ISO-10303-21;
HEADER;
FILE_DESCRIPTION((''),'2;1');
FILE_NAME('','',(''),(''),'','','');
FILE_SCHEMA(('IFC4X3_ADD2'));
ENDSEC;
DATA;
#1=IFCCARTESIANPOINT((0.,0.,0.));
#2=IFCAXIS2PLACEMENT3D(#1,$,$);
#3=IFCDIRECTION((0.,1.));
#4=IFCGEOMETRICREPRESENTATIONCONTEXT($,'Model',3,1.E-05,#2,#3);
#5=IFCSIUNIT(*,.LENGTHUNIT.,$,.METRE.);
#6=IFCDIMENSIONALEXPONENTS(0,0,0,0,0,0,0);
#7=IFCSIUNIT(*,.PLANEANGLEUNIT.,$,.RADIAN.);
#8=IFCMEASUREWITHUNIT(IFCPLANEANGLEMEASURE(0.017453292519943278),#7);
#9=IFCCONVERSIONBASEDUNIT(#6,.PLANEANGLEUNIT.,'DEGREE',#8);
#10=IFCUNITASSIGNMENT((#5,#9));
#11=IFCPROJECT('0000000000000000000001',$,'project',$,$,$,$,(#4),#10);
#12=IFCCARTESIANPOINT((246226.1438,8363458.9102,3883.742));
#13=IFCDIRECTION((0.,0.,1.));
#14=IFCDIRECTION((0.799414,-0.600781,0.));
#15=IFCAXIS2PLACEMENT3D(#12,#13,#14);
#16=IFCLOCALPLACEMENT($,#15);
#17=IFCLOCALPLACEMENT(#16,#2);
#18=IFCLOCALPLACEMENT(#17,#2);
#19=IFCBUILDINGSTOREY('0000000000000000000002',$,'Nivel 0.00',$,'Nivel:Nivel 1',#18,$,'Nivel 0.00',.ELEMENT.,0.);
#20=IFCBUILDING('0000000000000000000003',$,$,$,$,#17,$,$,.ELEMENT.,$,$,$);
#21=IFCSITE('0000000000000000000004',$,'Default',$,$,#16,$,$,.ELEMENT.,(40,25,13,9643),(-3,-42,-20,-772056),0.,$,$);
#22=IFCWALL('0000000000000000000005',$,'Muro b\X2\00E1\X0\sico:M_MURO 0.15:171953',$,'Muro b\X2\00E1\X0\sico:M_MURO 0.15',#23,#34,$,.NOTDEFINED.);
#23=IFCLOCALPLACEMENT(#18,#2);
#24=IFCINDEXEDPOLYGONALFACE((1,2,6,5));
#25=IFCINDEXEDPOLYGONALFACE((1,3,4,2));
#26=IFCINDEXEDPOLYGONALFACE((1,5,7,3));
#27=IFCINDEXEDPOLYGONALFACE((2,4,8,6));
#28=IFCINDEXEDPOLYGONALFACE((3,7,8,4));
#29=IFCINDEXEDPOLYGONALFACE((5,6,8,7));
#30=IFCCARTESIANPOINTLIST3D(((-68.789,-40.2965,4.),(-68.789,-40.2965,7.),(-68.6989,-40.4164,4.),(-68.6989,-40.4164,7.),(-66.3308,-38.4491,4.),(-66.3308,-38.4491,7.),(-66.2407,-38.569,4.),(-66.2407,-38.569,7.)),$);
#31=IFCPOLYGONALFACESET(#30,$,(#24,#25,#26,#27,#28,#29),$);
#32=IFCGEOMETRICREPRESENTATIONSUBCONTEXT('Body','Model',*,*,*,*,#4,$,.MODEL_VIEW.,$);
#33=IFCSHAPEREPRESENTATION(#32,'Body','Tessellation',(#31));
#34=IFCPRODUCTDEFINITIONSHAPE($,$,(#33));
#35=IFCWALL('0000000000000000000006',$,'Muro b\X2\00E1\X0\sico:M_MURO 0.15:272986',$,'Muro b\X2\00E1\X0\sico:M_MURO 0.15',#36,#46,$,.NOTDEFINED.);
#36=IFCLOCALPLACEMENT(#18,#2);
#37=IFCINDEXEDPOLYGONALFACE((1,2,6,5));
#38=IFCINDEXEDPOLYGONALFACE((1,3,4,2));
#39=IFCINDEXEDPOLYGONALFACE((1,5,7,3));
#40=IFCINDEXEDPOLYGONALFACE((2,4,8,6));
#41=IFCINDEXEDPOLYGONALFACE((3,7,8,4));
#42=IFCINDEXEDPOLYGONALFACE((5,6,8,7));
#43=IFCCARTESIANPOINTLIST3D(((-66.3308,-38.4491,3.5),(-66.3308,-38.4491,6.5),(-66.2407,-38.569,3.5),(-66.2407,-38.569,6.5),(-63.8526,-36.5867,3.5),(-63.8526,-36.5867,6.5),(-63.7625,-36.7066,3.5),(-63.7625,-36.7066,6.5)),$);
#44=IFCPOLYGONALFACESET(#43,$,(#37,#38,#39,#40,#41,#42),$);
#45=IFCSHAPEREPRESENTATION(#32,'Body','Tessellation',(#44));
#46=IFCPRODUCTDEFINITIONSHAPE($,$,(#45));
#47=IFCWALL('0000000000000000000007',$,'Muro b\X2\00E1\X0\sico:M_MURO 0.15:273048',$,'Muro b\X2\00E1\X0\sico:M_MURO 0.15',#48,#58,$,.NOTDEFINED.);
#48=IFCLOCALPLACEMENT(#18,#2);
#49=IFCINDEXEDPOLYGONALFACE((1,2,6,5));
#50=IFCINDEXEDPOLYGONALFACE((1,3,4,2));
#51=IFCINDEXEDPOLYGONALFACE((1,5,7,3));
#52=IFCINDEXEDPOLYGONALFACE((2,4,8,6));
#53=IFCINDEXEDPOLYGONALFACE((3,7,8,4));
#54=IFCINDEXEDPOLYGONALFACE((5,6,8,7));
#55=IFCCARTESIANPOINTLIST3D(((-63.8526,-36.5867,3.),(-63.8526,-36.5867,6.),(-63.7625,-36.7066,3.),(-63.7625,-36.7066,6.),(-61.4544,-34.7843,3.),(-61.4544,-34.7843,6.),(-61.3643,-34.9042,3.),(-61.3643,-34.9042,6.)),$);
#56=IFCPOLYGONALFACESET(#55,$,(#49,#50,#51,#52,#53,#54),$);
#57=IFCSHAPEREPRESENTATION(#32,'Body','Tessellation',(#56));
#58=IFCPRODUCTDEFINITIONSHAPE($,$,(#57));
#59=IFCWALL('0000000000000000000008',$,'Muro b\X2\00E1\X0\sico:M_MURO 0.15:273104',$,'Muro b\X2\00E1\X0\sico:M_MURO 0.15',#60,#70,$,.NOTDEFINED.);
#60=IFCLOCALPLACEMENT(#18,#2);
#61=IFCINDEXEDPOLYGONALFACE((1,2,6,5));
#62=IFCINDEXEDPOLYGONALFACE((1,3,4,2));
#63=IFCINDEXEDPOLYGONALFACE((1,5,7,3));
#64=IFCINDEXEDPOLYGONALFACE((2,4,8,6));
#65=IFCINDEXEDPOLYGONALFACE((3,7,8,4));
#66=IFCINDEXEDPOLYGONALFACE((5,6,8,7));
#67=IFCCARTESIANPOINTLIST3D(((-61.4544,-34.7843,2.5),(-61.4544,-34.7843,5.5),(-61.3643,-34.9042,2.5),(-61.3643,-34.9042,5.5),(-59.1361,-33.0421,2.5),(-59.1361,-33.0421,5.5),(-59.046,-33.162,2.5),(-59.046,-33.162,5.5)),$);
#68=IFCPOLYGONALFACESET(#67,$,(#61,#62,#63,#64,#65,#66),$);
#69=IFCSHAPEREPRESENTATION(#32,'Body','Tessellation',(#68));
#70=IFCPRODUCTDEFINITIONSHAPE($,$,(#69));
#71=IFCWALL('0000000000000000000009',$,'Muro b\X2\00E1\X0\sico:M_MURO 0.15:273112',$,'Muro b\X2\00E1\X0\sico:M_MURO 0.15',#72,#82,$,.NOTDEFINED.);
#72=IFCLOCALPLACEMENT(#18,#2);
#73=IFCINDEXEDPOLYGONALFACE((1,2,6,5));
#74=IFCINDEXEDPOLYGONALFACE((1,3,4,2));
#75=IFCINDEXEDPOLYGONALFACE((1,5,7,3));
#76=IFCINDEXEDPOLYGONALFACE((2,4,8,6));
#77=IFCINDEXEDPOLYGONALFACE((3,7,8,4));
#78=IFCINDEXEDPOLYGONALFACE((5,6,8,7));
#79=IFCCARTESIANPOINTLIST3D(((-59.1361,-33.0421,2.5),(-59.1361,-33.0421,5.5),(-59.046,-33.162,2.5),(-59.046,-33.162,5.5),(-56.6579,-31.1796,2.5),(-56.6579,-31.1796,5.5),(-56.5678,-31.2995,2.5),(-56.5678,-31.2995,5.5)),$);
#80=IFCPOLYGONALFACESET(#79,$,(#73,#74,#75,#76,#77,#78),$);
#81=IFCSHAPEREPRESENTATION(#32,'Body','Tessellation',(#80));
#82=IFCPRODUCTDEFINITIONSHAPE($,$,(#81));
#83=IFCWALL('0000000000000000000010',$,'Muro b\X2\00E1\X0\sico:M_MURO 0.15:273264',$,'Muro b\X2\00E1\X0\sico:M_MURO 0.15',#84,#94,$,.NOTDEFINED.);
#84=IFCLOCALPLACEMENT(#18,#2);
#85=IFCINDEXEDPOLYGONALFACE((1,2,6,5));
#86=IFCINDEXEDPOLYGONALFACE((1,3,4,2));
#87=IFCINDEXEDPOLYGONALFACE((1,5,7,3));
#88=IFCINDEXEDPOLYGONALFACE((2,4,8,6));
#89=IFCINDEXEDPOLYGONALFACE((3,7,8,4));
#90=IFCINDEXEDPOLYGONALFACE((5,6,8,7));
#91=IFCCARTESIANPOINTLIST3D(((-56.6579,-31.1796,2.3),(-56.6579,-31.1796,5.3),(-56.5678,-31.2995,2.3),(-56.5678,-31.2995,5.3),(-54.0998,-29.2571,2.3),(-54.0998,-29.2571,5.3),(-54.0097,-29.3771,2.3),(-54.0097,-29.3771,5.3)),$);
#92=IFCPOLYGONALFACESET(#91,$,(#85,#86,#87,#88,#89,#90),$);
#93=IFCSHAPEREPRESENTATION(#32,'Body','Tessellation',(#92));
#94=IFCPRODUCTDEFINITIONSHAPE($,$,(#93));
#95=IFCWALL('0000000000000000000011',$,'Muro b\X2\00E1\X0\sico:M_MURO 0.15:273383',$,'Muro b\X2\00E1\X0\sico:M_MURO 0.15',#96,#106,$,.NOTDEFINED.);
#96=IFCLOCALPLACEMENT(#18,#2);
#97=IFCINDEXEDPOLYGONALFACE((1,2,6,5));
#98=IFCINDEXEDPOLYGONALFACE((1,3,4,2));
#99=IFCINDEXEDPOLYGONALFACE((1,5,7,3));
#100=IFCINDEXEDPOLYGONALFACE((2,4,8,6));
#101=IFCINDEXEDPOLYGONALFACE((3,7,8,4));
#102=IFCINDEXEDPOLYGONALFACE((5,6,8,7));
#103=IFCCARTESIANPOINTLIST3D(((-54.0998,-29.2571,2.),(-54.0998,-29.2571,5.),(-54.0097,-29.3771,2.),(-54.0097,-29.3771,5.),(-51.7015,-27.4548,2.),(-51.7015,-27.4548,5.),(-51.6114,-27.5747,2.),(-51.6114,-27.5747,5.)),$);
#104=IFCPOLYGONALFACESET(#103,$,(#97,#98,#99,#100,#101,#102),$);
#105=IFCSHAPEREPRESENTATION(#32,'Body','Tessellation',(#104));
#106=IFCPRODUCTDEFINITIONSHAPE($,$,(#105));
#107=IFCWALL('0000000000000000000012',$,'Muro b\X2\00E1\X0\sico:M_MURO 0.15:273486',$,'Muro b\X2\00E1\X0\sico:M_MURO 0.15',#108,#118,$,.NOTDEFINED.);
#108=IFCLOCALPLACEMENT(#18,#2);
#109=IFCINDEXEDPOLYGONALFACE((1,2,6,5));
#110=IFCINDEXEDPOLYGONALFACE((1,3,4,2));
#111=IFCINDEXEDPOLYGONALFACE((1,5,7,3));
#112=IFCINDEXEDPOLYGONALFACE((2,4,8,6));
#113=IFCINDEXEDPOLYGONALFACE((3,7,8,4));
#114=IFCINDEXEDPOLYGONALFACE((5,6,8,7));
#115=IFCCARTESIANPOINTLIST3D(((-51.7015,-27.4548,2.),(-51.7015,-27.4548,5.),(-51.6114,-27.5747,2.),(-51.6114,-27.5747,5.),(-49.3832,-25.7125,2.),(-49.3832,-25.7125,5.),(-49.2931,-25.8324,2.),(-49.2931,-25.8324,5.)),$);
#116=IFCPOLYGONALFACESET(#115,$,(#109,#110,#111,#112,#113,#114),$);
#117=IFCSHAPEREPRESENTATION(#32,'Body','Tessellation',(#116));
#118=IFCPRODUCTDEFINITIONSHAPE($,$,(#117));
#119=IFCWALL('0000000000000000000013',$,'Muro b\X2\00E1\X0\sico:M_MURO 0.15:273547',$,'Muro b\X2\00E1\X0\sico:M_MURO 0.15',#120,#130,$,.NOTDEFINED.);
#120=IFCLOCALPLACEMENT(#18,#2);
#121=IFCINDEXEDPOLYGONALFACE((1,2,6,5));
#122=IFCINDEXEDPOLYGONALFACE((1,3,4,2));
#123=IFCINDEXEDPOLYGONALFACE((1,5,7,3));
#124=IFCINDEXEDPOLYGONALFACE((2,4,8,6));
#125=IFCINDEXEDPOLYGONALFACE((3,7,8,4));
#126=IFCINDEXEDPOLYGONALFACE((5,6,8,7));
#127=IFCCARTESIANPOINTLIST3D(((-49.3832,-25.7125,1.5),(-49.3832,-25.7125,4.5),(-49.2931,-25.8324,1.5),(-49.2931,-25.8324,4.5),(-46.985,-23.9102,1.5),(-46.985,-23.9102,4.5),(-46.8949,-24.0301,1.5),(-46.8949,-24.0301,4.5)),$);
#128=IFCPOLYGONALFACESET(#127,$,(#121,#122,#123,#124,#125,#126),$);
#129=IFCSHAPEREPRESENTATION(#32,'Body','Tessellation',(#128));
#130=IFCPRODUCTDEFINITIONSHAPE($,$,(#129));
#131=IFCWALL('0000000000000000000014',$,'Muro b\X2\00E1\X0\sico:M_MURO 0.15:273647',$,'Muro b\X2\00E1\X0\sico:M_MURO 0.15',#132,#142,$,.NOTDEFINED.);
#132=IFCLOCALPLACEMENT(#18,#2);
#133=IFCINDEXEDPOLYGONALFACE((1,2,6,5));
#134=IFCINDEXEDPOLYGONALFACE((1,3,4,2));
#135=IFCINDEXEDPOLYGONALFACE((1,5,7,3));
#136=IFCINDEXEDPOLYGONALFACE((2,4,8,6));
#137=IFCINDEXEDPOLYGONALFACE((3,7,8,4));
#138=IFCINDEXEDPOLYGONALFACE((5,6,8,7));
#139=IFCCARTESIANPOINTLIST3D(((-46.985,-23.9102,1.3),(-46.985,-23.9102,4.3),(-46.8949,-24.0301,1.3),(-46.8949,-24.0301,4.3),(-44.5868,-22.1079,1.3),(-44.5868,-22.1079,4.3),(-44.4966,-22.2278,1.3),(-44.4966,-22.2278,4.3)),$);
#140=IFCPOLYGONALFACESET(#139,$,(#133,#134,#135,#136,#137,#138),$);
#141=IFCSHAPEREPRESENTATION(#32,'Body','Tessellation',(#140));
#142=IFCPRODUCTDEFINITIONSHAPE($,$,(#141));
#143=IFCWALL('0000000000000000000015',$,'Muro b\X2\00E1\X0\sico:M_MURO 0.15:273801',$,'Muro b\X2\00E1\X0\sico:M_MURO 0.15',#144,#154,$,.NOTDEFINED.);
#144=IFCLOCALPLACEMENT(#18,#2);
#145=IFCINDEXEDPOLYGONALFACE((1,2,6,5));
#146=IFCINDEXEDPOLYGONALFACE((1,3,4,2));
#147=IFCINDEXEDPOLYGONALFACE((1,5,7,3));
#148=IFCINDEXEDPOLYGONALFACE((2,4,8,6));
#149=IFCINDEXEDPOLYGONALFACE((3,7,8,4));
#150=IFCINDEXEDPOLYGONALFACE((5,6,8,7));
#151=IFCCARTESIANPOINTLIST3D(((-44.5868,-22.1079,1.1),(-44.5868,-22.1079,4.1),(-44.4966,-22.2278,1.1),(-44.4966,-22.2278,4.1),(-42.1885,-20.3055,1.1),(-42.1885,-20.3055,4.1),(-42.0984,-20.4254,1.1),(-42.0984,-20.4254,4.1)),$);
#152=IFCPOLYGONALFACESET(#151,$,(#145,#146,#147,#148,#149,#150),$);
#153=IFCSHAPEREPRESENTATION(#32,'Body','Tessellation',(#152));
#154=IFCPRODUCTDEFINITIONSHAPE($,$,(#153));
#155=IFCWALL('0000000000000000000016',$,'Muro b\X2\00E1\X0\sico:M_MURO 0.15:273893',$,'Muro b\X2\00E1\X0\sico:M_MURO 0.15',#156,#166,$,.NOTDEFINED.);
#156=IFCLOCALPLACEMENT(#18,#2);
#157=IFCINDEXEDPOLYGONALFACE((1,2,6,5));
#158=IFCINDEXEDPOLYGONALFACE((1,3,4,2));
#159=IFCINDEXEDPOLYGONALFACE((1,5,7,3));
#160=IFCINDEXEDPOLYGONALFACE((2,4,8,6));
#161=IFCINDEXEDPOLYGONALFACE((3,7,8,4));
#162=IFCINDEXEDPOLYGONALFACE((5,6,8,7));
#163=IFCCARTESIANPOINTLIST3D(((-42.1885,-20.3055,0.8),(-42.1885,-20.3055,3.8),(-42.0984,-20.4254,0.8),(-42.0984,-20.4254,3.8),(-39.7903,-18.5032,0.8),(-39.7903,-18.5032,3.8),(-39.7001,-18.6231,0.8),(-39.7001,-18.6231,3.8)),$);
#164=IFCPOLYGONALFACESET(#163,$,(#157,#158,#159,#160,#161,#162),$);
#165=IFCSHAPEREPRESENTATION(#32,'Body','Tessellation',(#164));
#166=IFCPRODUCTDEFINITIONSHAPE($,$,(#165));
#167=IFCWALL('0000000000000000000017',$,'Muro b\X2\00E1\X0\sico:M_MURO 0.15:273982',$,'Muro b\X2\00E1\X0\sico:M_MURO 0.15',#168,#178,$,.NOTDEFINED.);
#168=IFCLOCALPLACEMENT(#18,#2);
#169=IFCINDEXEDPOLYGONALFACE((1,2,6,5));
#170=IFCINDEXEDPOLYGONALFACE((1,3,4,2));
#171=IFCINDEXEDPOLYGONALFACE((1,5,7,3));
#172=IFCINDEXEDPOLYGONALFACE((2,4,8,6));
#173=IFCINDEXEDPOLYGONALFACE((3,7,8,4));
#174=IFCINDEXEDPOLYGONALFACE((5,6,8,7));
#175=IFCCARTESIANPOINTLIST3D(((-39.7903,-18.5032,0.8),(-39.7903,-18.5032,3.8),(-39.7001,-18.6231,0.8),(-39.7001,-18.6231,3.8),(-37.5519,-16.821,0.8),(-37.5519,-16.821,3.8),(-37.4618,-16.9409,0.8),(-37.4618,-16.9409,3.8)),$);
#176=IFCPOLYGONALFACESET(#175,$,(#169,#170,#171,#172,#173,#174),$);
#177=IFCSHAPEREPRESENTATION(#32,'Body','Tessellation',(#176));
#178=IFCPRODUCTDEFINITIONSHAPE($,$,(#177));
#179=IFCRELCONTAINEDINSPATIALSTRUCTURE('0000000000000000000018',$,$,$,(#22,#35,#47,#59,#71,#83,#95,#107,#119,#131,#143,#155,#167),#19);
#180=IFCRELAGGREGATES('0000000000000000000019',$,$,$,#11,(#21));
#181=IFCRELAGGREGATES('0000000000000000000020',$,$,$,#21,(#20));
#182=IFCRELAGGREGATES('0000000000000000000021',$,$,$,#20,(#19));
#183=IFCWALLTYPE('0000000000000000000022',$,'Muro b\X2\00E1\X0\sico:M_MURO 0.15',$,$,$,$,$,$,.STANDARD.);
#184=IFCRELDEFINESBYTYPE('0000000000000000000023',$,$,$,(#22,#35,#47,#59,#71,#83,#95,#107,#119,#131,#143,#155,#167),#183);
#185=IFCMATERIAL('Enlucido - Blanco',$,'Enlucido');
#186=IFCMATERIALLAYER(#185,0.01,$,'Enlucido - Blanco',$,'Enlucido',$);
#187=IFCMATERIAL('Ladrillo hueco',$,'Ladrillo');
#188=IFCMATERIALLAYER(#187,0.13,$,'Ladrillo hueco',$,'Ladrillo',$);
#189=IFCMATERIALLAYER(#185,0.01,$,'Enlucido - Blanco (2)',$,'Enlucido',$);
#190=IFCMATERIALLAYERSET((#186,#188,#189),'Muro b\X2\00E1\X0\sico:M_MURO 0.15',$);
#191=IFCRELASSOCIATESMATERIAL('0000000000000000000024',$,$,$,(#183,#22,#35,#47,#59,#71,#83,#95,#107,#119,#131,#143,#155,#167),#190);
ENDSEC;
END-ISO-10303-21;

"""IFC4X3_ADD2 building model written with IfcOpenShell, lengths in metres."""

from ifc_helpers import new_model, entity, si_unit, converted_unit, direction, frame, frame_2d, origin, place, context, subcontext, project, spatial, rectangle, extrude, material, layer, layer_set, type_object, element, save


model = new_model("IFC4X3_ADD2")

# Units and contexts
model_context = context("Model", 3, precision=1e-05, world=origin(), true_north=direction((0.0, 1.0)))
body_context = subcontext(model_context, "Body", "Model", "MODEL_VIEW")
ifc_project = project(units=[si_unit("LENGTHUNIT", "METRE"), converted_unit("PLANEANGLEUNIT", "DEGREE", entity("IfcPlaneAngleMeasure", 0.017453292519943278), si_unit("PLANEANGLEUNIT", "RADIAN"), dimensions=[0, 0, 0, 0, 0, 0, 0])], contexts=[model_context])

# Site, building, storey
site_placement = place(None, frame((246226.1438, 8363458.9102, 3883.742), z_axis=(0.0, 0.0, 1.0), x_axis=(0.799414, -0.600781, 0.0)))
site = spatial("IfcSite", under=ifc_project, at=site_placement, Name="Default", CompositionType="ELEMENT", RefLatitude=(40, 25, 13, 9643), RefLongitude=(-3, -42, -20, -772056), RefElevation=0.0)
building_placement = place(site_placement, origin())
building = spatial("IfcBuilding", under=site, at=building_placement, CompositionType="ELEMENT")
storey_placement = place(building_placement, origin())
storey = spatial("IfcBuildingStorey", under=building, at=storey_placement, Name="Nivel 0.00", ObjectType="Nivel:Nivel 1", LongName="Nivel 0.00", CompositionType="ELEMENT", Elevation=0.0)

# Walls
ifc_material_1 = material(Name="Enlucido - Blanco", Category="Enlucido")
ifc_layer_1 = layer(ifc_material_1, 0.01, Name="Enlucido - Blanco", Category="Enlucido")
ifc_material_2 = material(Name="Ladrillo hueco", Category="Ladrillo")
ifc_layer_2 = layer(ifc_material_2, 0.13, Name="Ladrillo hueco", Category="Ladrillo")
ifc_layer_3 = layer(ifc_material_1, 0.01, Name="Enlucido - Blanco (2)", Category="Enlucido")
ifc_layer_set = layer_set([ifc_layer_1, ifc_layer_2, ifc_layer_3], Name="Muro básico:M_MURO 0.15")
wall_type = type_object("IfcWallType", Name="Muro básico:M_MURO 0.15", PredefinedType="STANDARD", material=ifc_layer_set)
wall_1_placement = place(storey_placement, frame((-68.744, -40.3564, 4.0), z_axis=(0.0, 0.0, 1.0), x_axis=(0.799414, 0.60078, 0.0)))
element("IfcWall", 1, at=wall_1_placement, inside=storey, type_object=wall_type, material=ifc_layer_set, Name="Muro básico:M_MURO 0.15:171953", ObjectType="Muro básico:M_MURO 0.15", PredefinedType="NOTDEFINED", context=body_context, shape_type="SweptSolid", body=[
    extrude(rectangle(XDim=3.075, YDim=0.15, at=frame_2d((1.5375, 0.0), x_axis=(-1.0, 0.0))), origin(), (0.0, 0.0, 1.0), 3.0),
])
wall_2_placement = place(storey_placement, frame((-66.2858, -38.509, 3.5), z_axis=(0.0, 0.0, 1.0), x_axis=(0.799414, 0.60078, 0.0)))
element("IfcWall", 2, at=wall_2_placement, inside=storey, type_object=wall_type, material=ifc_layer_set, Name="Muro básico:M_MURO 0.15:272986", ObjectType="Muro básico:M_MURO 0.15", PredefinedType="NOTDEFINED", context=body_context, shape_type="SweptSolid", body=[
    extrude(rectangle(XDim=3.1, YDim=0.15, at=frame_2d((1.55, 0.0), x_axis=(-1.0, 0.0))), origin(), (0.0, 0.0, 1.0), 3.0),
])
wall_3_placement = place(storey_placement, frame((-63.8076, -36.6466, 3.0), z_axis=(0.0, 0.0, 1.0), x_axis=(0.799414, 0.60078, 0.0)))
element("IfcWall", 3, at=wall_3_placement, inside=storey, type_object=wall_type, material=ifc_layer_set, Name="Muro básico:M_MURO 0.15:273048", ObjectType="Muro básico:M_MURO 0.15", PredefinedType="NOTDEFINED", context=body_context, shape_type="SweptSolid", body=[
    extrude(rectangle(XDim=3.0, YDim=0.15, at=frame_2d((1.5, 0.0), x_axis=(-1.0, 0.0))), origin(), (0.0, 0.0, 1.0), 3.0),
])
wall_4_placement = place(storey_placement, frame((-61.4093, -34.8443, 2.5), z_axis=(0.0, 0.0, 1.0), x_axis=(0.799414, 0.60078, 0.0)))
element("IfcWall", 4, at=wall_4_placement, inside=storey, type_object=wall_type, material=ifc_layer_set, Name="Muro básico:M_MURO 0.15:273104", ObjectType="Muro básico:M_MURO 0.15", PredefinedType="NOTDEFINED", context=body_context, shape_type="SweptSolid", body=[
    extrude(rectangle(XDim=2.9, YDim=0.15, at=frame_2d((1.45, 0.0), x_axis=(-1.0, 0.0))), origin(), (0.0, 0.0, 1.0), 3.0),
])
wall_5_placement = place(storey_placement, frame((-59.091, -33.102, 2.5), z_axis=(0.0, 0.0, 1.0), x_axis=(0.799414, 0.60078, 0.0)))
element("IfcWall", 5, at=wall_5_placement, inside=storey, type_object=wall_type, material=ifc_layer_set, Name="Muro básico:M_MURO 0.15:273112", ObjectType="Muro básico:M_MURO 0.15", PredefinedType="NOTDEFINED", context=body_context, shape_type="SweptSolid", body=[
    extrude(rectangle(XDim=3.1, YDim=0.15, at=frame_2d((1.55, 0.0), x_axis=(-1.0, 0.0))), origin(), (0.0, 0.0, 1.0), 3.0),
])
wall_6_placement = place(storey_placement, frame((-56.6129, -31.2396, 2.3), z_axis=(0.0, 0.0, 1.0), x_axis=(0.799414, 0.60078, 0.0)))
element("IfcWall", 6, at=wall_6_placement, inside=storey, type_object=wall_type, material=ifc_layer_set, Name="Muro básico:M_MURO 0.15:273264", ObjectType="Muro básico:M_MURO 0.15", PredefinedType="NOTDEFINED", context=body_context, shape_type="SweptSolid", body=[
    extrude(rectangle(XDim=3.2, YDim=0.15, at=frame_2d((1.6, 0.0), x_axis=(-1.0, 0.0))), origin(), (0.0, 0.0, 1.0), 3.0),
])
wall_7_placement = place(storey_placement, frame((-54.0547, -29.3171, 2.0), z_axis=(0.0, 0.0, 1.0), x_axis=(0.799414, 0.60078, 0.0)))
element("IfcWall", 7, at=wall_7_placement, inside=storey, type_object=wall_type, material=ifc_layer_set, Name="Muro básico:M_MURO 0.15:273383", ObjectType="Muro básico:M_MURO 0.15", PredefinedType="NOTDEFINED", context=body_context, shape_type="SweptSolid", body=[
    extrude(rectangle(XDim=3.0, YDim=0.15, at=frame_2d((1.5, 0.0), x_axis=(-1.0, 0.0))), origin(), (0.0, 0.0, 1.0), 3.0),
])
wall_8_placement = place(storey_placement, frame((-51.6565, -27.5148, 2.0), z_axis=(0.0, 0.0, 1.0), x_axis=(0.799414, 0.60078, 0.0)))
element("IfcWall", 8, at=wall_8_placement, inside=storey, type_object=wall_type, material=ifc_layer_set, Name="Muro básico:M_MURO 0.15:273486", ObjectType="Muro básico:M_MURO 0.15", PredefinedType="NOTDEFINED", context=body_context, shape_type="SweptSolid", body=[
    extrude(rectangle(XDim=2.9, YDim=0.15, at=frame_2d((1.45, 0.0), x_axis=(-1.0, 0.0))), origin(), (0.0, 0.0, 1.0), 3.0),
])
wall_9_placement = place(storey_placement, frame((-49.3382, -25.7725, 1.5), z_axis=(0.0, 0.0, 1.0), x_axis=(0.799414, 0.60078, 0.0)))
element("IfcWall", 9, at=wall_9_placement, inside=storey, type_object=wall_type, material=ifc_layer_set, Name="Muro básico:M_MURO 0.15:273547", ObjectType="Muro básico:M_MURO 0.15", PredefinedType="NOTDEFINED", context=body_context, shape_type="SweptSolid", body=[
    extrude(rectangle(XDim=3.0, YDim=0.15, at=frame_2d((1.5, 0.0), x_axis=(-1.0, 0.0))), origin(), (0.0, 0.0, 1.0), 3.0),
])
wall_10_placement = place(storey_placement, frame((-46.9399, -23.9702, 1.3), z_axis=(0.0, 0.0, 1.0), x_axis=(0.799414, 0.60078, 0.0)))
element("IfcWall", 10, at=wall_10_placement, inside=storey, type_object=wall_type, material=ifc_layer_set, Name="Muro básico:M_MURO 0.15:273647", ObjectType="Muro básico:M_MURO 0.15", PredefinedType="NOTDEFINED", context=body_context, shape_type="SweptSolid", body=[
    extrude(rectangle(XDim=3.0, YDim=0.15, at=frame_2d((1.5, 0.0), x_axis=(-1.0, 0.0))), origin(), (0.0, 0.0, 1.0), 3.0),
])
wall_11_placement = place(storey_placement, frame((-44.5417, -22.1678, 1.1), z_axis=(0.0, 0.0, 1.0), x_axis=(0.799414, 0.60078, 0.0)))
element("IfcWall", 11, at=wall_11_placement, inside=storey, type_object=wall_type, material=ifc_layer_set, Name="Muro básico:M_MURO 0.15:273801", ObjectType="Muro básico:M_MURO 0.15", PredefinedType="NOTDEFINED", context=body_context, shape_type="SweptSolid", body=[
    extrude(rectangle(XDim=3.0, YDim=0.15, at=frame_2d((1.5, 0.0), x_axis=(-1.0, 0.0))), origin(), (0.0, 0.0, 1.0), 3.0),
])
wall_12_placement = place(storey_placement, frame((-42.1435, -20.3655, 0.8), z_axis=(0.0, 0.0, 1.0), x_axis=(0.799414, 0.60078, 0.0)))
element("IfcWall", 12, at=wall_12_placement, inside=storey, type_object=wall_type, material=ifc_layer_set, Name="Muro básico:M_MURO 0.15:273893", ObjectType="Muro básico:M_MURO 0.15", PredefinedType="NOTDEFINED", context=body_context, shape_type="SweptSolid", body=[
    extrude(rectangle(XDim=3.0, YDim=0.15, at=frame_2d((1.5, 0.0), x_axis=(-1.0, 0.0))), origin(), (0.0, 0.0, 1.0), 3.0),
])
wall_13_placement = place(storey_placement, frame((-39.7452, -18.5631, 0.8), z_axis=(0.0, 0.0, 1.0), x_axis=(0.799414, 0.60078, 0.0)))
element("IfcWall", 13, at=wall_13_placement, inside=storey, type_object=wall_type, material=ifc_layer_set, Name="Muro básico:M_MURO 0.15:273982", ObjectType="Muro básico:M_MURO 0.15", PredefinedType="NOTDEFINED", context=body_context, shape_type="SweptSolid", body=[
    extrude(rectangle(XDim=2.8, YDim=0.15, at=frame_2d((1.4, 0.0), x_axis=(-1.0, 0.0))), origin(), (0.0, 0.0, 1.0), 3.0),
])

save(model, "model.ifc")
